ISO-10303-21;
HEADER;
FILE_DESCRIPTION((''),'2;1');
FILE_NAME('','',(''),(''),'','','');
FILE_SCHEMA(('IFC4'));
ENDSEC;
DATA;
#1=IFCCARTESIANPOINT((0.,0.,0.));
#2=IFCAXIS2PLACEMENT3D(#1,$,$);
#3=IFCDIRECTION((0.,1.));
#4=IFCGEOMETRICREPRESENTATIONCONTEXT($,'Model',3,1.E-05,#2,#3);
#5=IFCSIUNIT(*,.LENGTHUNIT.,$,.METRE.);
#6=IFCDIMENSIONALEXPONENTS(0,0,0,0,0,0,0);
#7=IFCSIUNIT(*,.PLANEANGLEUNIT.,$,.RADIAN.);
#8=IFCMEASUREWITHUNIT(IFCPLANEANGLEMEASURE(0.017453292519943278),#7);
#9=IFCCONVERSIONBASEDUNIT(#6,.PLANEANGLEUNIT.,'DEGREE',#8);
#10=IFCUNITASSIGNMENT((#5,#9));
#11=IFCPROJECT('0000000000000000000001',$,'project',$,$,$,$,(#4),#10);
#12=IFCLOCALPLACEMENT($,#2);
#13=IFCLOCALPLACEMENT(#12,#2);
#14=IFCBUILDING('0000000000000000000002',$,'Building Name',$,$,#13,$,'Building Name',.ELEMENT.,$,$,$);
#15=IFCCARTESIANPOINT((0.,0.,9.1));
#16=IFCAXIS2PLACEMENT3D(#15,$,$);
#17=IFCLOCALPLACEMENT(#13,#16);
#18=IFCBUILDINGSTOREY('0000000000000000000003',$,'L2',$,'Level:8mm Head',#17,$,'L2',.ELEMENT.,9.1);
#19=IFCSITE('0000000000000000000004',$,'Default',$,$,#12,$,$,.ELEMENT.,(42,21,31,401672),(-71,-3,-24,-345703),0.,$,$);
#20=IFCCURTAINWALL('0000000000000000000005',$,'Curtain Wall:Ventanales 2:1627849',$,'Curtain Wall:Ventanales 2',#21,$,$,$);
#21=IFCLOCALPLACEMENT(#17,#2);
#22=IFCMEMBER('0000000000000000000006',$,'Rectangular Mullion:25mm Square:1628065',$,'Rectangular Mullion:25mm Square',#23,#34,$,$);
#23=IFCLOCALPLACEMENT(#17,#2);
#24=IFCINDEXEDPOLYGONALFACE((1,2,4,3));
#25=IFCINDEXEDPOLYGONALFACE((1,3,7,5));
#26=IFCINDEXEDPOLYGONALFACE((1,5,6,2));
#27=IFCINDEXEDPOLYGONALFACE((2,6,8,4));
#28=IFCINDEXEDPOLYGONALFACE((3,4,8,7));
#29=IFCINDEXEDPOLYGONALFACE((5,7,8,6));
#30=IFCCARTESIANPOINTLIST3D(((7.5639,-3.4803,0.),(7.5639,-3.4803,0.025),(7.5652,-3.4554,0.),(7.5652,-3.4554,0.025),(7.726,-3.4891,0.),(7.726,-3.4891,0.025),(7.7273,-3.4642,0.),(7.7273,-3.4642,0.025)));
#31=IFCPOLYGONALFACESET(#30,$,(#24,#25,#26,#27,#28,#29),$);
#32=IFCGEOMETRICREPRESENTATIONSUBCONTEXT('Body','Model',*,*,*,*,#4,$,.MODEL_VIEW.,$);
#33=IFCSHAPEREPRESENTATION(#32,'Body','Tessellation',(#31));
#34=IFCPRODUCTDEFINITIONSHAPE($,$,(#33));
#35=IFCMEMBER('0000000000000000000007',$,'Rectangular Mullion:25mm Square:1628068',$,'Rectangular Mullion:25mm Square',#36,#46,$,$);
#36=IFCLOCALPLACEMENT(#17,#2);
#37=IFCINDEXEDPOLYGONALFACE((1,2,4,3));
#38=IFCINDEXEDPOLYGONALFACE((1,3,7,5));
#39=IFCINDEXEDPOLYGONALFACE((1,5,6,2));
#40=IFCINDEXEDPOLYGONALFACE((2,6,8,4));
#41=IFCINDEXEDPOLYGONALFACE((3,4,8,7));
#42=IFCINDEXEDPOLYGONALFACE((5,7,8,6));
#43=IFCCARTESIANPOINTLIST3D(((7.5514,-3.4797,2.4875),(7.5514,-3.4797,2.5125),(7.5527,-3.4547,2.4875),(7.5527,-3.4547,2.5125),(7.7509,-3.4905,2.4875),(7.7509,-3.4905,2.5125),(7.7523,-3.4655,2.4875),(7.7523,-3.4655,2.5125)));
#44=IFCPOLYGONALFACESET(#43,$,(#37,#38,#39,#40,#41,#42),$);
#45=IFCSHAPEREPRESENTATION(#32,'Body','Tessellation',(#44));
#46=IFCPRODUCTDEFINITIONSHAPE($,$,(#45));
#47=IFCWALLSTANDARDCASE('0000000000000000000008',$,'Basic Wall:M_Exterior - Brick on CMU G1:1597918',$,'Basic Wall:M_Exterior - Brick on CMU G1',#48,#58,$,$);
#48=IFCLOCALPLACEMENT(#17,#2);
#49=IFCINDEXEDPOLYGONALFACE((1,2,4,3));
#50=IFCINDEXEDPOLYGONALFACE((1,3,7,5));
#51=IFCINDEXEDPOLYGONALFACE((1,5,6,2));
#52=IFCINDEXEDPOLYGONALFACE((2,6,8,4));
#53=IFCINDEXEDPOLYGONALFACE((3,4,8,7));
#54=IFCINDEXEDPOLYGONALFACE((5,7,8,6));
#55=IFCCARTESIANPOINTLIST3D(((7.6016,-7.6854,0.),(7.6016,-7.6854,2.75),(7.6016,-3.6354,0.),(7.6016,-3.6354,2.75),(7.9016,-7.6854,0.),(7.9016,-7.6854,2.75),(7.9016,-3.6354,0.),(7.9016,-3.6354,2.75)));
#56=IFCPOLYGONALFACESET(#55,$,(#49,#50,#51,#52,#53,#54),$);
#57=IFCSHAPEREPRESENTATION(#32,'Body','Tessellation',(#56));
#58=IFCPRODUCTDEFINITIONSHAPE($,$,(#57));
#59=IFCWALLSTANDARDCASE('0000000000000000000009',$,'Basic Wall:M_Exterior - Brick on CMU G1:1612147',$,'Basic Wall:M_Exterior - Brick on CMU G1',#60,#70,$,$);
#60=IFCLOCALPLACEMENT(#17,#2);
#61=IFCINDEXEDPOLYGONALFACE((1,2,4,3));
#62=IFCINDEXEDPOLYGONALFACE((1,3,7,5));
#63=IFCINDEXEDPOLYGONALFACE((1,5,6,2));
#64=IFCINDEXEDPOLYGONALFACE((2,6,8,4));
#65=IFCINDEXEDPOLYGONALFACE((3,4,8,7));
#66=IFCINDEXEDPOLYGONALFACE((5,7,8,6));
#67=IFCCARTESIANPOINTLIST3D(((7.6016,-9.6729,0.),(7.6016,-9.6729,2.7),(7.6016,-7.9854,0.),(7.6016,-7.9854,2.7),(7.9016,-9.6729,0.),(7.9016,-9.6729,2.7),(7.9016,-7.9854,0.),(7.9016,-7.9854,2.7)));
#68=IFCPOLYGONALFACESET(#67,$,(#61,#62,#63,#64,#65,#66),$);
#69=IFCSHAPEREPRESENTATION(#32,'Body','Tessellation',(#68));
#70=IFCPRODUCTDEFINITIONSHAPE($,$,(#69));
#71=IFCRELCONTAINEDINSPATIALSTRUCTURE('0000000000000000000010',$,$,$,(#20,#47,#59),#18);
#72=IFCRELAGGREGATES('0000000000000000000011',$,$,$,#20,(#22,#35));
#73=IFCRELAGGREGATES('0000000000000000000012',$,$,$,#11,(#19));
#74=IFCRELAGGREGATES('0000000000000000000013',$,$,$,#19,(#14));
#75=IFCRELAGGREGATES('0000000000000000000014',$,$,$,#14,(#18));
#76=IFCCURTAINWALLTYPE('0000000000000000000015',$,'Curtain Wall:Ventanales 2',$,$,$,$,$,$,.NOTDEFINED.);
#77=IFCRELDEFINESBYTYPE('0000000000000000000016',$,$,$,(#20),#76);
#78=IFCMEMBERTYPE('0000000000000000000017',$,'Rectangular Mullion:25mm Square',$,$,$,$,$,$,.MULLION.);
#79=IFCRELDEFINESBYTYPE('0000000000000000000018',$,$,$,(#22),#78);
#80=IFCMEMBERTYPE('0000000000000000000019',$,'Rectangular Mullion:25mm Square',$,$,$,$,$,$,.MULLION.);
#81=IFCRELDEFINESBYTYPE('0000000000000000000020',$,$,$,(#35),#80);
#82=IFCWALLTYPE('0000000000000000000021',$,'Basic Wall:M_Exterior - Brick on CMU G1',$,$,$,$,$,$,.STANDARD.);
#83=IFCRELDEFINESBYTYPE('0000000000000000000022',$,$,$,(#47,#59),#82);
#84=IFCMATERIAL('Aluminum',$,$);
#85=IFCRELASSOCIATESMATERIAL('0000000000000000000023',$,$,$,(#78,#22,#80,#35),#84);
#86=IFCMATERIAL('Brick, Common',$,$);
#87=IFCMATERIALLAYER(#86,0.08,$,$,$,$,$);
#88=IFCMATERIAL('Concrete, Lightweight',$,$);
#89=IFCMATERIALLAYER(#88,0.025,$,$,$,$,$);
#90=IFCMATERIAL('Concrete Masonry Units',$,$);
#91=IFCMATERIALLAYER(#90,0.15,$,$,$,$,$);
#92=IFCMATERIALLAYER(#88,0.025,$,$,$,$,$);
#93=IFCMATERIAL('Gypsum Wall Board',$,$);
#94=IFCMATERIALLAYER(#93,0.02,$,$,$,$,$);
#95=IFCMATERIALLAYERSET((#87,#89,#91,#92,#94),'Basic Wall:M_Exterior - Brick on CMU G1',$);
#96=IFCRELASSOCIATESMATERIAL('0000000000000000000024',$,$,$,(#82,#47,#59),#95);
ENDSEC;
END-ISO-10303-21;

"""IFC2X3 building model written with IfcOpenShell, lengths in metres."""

from ifc_helpers import new_model, entity, si_unit, converted_unit, direction, frame, frame_2d, origin, origin_2d_with_axis, place, context, subcontext, project, spatial, rectangle, extrude, source, transform, mapped, material, layer, layer_set, layer_usage, type_object, type_shapes, element, aggregate, save


model = new_model("IFC2X3")

# Units and contexts
model_context = context("Model", 3, precision=1e-05, world=origin(), true_north=direction((0.0, 1.0)))
body_context = subcontext(model_context, "Body", "Model", "MODEL_VIEW")
ifc_project = project(units=[si_unit("LENGTHUNIT", "METRE"), converted_unit("PLANEANGLEUNIT", "DEGREE", entity("IfcPlaneAngleMeasure", 0.017453292519943278), si_unit("PLANEANGLEUNIT", "RADIAN"), dimensions=[0, 0, 0, 0, 0, 0, 0])], contexts=[model_context])

# Site, building, storey
site_placement = place(None, origin())
site = spatial("IfcSite", under=ifc_project, at=site_placement, Name="Default", CompositionType="ELEMENT", RefLatitude=(42, 21, 31, 401672), RefLongitude=(-71, -3, -24, -345703), RefElevation=0.0)
building_placement = place(site_placement, origin())
building = spatial("IfcBuilding", under=site, at=building_placement, Name="Building Name", LongName="Building Name", CompositionType="ELEMENT")
storey_placement = place(building_placement, frame((0.0, 0.0, 9.1)))
storey = spatial("IfcBuildingStorey", under=building, at=storey_placement, Name="L2", ObjectType="Level:8mm Head", LongName="L2", CompositionType="ELEMENT", Elevation=9.1)

# Curtain wall, members
curtain_wall_type = type_object("IfcCurtainWallType", Name="Curtain Wall:Ventanales 2", PredefinedType="NOTDEFINED")
curtain_wall_placement = place(storey_placement, frame((0.0, 0.0, -9.1)))
curtain_wall = element("IfcCurtainWall", 1, at=curtain_wall_placement, inside=storey, type_object=curtain_wall_type, Name="Curtain Wall:Ventanales 2:1627849", ObjectType="Curtain Wall:Ventanales 2")
ifc_material_1 = material(Name="Aluminum")
member_type_1 = type_object("IfcMemberType", Name="Rectangular Mullion:25mm Square", PredefinedType="MULLION", material=ifc_material_1)
shared_shape_1 = source(origin(), body_context, "Body", "SweptSolid", [
    extrude(rectangle(XDim=0.025, YDim=0.025, at=origin_2d_with_axis()), frame((-0.0125, 0.0, -0.1623), z_axis=(0.0, 0.0, 1.0), x_axis=(-1.0, 0.0, 0.0)), (0.0, 0.0, 1.0), 0.1623),
])
type_shapes(member_type_1, [shared_shape_1])
member_1_placement = place(curtain_wall_placement, frame((7.5646, -3.4679, 9.1), z_axis=(-0.998536, 0.054083, 0.0), x_axis=(0.0, 0.0, -1.0)))
member_1 = element("IfcMember", 2, at=member_1_placement, type_object=member_type_1, material=ifc_material_1, Name="Rectangular Mullion:25mm Square:1628065", ObjectType="Rectangular Mullion:25mm Square", context=body_context, shape_type="MappedRepresentation", body=[
    mapped(shared_shape_1, transform((0.0, 0.0, 0.0), scale=1.0)),
])
member_type_2 = type_object("IfcMemberType", Name="Rectangular Mullion:25mm Square", PredefinedType="MULLION", material=ifc_material_1)
shared_shape_2 = source(origin(), body_context, "Body", "SweptSolid", [
    extrude(rectangle(XDim=0.025, YDim=0.025, at=frame_2d((0.0, 0.0), x_axis=(1.0, 0.0))), frame((0.0, 0.0, -0.1998), z_axis=(0.0, 0.0, 1.0), x_axis=(-1.0, 0.0, 0.0)), (0.0, 0.0, 1.0), 0.1998),
])
type_shapes(member_type_2, [shared_shape_2])
member_2_placement = place(curtain_wall_placement, frame((7.7516, -3.478, 11.6), z_axis=(0.998536, -0.054083, 0.0), x_axis=(0.0, 0.0, 1.0)))
member_2 = element("IfcMember", 3, at=member_2_placement, type_object=member_type_2, material=ifc_material_1, Name="Rectangular Mullion:25mm Square:1628068", ObjectType="Rectangular Mullion:25mm Square", context=body_context, shape_type="MappedRepresentation", body=[
    mapped(shared_shape_2, transform((0.0, 0.0, 0.0), scale=1.0)),
])
aggregate(curtain_wall, [member_1, member_2])

# Walls
ifc_material_2 = material(Name="Brick, Common")
ifc_layer_1 = layer(ifc_material_2, 0.08)
ifc_material_3 = material(Name="Concrete, Lightweight")
ifc_layer_2 = layer(ifc_material_3, 0.025)
ifc_material_4 = material(Name="Concrete Masonry Units")
ifc_layer_3 = layer(ifc_material_4, 0.15)
ifc_layer_4 = layer(ifc_material_3, 0.025)
ifc_material_5 = material(Name="Gypsum Wall Board")
ifc_layer_5 = layer(ifc_material_5, 0.02)
ifc_layer_set = layer_set([ifc_layer_1, ifc_layer_2, ifc_layer_3, ifc_layer_4, ifc_layer_5], Name="Basic Wall:M_Exterior - Brick on CMU G1")
ifc_layer_usage_1 = layer_usage(ifc_layer_set, "AXIS2", "NEGATIVE", 0.15)
wall_type = type_object("IfcWallType", Name="Basic Wall:M_Exterior - Brick on CMU G1", PredefinedType="STANDARD", material=ifc_layer_set)
wall_1_placement = place(storey_placement, frame((7.7516, -3.6354, 0.0), z_axis=(0.0, 0.0, 1.0), x_axis=(0.0, -1.0, 0.0)))
element("IfcWallStandardCase", 4, at=wall_1_placement, inside=storey, type_object=wall_type, material=ifc_layer_usage_1, Name="Basic Wall:M_Exterior - Brick on CMU G1:1597918", ObjectType="Basic Wall:M_Exterior - Brick on CMU G1", context=body_context, shape_type="SweptSolid", body=[
    extrude(rectangle(XDim=4.05, YDim=0.3, at=frame_2d((2.025, 0.0), x_axis=(-1.0, 0.0))), origin(), (0.0, 0.0, 1.0), 2.75),
])
ifc_layer_usage_2 = layer_usage(ifc_layer_set, "AXIS2", "NEGATIVE", 0.15)
wall_2_placement = place(storey_placement, frame((7.7516, -7.9854, 0.0), z_axis=(0.0, 0.0, 1.0), x_axis=(0.0, -1.0, 0.0)))
element("IfcWallStandardCase", 5, at=wall_2_placement, inside=storey, type_object=wall_type, material=ifc_layer_usage_2, Name="Basic Wall:M_Exterior - Brick on CMU G1:1612147", ObjectType="Basic Wall:M_Exterior - Brick on CMU G1", context=body_context, shape_type="SweptSolid", body=[
    extrude(rectangle(XDim=1.6875, YDim=0.3, at=frame_2d((0.8438, 0.0), x_axis=(-1.0, 0.0))), origin(), (0.0, 0.0, 1.0), 2.7),
])

save(model, "model.ifc")
